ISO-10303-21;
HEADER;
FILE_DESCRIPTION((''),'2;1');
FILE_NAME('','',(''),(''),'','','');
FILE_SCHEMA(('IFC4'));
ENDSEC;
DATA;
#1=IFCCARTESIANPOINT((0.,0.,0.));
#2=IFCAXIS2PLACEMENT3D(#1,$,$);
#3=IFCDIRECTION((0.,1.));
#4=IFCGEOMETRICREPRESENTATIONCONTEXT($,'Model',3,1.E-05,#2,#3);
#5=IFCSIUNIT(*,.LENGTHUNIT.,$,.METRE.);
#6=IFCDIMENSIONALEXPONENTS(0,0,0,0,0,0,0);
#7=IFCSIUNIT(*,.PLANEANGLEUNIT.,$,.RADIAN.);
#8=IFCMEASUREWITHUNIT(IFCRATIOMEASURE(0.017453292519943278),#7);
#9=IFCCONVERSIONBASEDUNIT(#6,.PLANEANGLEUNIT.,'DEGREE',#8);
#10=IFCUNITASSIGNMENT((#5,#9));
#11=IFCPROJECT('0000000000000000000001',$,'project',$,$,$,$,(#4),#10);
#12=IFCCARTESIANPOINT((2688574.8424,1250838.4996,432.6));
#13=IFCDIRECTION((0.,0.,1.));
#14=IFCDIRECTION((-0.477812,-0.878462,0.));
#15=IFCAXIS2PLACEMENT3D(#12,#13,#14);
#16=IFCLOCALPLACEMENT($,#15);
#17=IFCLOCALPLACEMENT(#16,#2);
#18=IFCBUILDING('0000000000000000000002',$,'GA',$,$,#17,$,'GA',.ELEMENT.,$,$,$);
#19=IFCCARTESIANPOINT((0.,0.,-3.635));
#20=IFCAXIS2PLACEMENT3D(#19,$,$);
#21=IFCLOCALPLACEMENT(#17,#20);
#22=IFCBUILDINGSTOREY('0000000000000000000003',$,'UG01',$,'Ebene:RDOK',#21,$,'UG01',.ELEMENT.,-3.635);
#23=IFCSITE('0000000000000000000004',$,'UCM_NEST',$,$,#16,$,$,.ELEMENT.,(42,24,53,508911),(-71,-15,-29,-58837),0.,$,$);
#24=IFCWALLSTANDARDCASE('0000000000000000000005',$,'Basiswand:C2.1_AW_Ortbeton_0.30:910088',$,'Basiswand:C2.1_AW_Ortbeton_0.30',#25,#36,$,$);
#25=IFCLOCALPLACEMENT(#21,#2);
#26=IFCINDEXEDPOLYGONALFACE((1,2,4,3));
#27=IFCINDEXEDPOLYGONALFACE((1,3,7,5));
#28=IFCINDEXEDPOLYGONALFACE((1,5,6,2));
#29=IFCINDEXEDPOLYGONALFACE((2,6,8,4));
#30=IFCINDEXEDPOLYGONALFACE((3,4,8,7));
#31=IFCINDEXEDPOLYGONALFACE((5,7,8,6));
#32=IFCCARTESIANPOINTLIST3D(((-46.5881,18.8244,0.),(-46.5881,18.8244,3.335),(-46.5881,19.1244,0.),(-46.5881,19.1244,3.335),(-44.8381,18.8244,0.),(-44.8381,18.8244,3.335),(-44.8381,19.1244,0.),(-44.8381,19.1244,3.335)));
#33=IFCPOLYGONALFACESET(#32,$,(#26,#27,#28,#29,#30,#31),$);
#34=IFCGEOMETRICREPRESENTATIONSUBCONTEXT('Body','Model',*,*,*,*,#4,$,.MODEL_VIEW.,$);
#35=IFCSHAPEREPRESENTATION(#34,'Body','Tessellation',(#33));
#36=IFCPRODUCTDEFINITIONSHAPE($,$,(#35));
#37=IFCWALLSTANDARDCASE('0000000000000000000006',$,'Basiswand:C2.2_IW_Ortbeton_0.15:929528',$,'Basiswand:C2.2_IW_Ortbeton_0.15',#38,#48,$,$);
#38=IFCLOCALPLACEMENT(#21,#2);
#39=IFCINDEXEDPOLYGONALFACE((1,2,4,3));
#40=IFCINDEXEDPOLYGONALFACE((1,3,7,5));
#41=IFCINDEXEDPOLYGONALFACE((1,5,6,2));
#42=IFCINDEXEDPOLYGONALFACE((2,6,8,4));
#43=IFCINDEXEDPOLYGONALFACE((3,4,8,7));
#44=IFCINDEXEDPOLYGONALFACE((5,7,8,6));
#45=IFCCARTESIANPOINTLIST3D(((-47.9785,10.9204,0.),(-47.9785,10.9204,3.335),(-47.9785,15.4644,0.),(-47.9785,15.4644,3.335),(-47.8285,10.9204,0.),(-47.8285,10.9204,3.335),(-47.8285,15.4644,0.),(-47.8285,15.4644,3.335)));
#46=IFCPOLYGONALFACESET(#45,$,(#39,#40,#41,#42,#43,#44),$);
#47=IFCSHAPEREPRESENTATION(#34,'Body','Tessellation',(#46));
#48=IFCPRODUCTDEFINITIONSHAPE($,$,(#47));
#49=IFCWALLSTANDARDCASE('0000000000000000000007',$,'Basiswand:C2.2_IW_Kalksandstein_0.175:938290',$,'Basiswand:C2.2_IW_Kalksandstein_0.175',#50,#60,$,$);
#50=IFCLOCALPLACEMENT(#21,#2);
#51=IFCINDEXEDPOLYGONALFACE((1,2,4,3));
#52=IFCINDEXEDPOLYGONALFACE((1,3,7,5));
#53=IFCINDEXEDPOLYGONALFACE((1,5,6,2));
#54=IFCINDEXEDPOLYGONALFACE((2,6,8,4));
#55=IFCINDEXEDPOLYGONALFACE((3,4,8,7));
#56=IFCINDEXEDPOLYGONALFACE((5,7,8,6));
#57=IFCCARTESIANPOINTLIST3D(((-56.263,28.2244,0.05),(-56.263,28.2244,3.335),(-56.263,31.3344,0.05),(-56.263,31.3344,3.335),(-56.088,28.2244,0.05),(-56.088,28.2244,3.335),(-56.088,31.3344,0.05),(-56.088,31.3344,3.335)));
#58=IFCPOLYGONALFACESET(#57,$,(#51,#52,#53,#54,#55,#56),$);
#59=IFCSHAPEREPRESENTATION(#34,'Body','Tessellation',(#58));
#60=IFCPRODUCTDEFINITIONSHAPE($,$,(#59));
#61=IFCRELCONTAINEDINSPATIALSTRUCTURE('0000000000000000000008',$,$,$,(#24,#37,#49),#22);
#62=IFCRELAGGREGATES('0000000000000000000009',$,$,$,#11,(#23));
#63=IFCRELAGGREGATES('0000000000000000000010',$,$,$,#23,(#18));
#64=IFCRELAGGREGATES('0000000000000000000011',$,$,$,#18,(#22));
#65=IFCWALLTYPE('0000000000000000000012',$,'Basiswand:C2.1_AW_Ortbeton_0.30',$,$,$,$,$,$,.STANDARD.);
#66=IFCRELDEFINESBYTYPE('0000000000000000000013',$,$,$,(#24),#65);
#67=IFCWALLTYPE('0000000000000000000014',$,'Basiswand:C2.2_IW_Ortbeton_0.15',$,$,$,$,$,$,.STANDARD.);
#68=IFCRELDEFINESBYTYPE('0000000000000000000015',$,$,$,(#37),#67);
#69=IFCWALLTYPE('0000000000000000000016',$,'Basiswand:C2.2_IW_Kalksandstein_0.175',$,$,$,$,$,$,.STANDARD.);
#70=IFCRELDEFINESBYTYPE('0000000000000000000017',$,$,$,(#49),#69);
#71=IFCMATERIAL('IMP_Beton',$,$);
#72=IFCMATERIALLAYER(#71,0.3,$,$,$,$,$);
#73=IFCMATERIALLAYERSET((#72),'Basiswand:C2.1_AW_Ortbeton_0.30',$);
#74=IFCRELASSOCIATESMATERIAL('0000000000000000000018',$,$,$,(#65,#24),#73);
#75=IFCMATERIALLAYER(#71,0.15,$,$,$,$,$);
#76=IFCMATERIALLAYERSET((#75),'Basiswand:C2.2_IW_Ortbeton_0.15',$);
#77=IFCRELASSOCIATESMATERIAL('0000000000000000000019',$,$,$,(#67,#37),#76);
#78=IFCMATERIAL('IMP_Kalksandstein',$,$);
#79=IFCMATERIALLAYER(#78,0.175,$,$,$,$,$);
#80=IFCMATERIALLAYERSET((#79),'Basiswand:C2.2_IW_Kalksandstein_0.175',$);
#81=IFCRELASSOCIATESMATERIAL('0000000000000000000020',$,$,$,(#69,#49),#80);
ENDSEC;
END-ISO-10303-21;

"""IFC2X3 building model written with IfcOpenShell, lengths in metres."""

from ifc_helpers import new_model, entity, si_unit, converted_unit, direction, frame, frame_2d, origin, place, context, subcontext, project, spatial, polyline, rectangle, extrude, clip, bounded_halfspace, material, layer, layer_set, layer_usage, type_object, element, save


model = new_model("IFC2X3")

# Units and contexts
model_context = context("Model", 3, precision=1e-05, world=origin(), true_north=direction((0.0, 1.0)))
body_context = subcontext(model_context, "Body", "Model", "MODEL_VIEW")
ifc_project = project(units=[si_unit("LENGTHUNIT", "METRE"), converted_unit("PLANEANGLEUNIT", "DEGREE", entity("IfcRatioMeasure", 0.017453292519943278), si_unit("PLANEANGLEUNIT", "RADIAN"), dimensions=[0, 0, 0, 0, 0, 0, 0])], contexts=[model_context])

# Site, building, storey
site_placement = place(None, frame((2688574.8424, 1250838.4996, 432.6), z_axis=(0.0, 0.0, 1.0), x_axis=(-0.477812, -0.878462, 0.0)))
site = spatial("IfcSite", under=ifc_project, at=site_placement, Name="UCM_NEST", CompositionType="ELEMENT", RefLatitude=(42, 24, 53, 508911), RefLongitude=(-71, -15, -29, -58837), RefElevation=0.0)
building_placement = place(site_placement, origin())
building = spatial("IfcBuilding", under=site, at=building_placement, Name="GA", LongName="GA", CompositionType="ELEMENT")
storey_placement = place(building_placement, frame((0.0, 0.0, -3.635)))
storey = spatial("IfcBuildingStorey", under=building, at=storey_placement, Name="UG01", ObjectType="Ebene:RDOK", LongName="UG01", CompositionType="ELEMENT", Elevation=-3.635)

# Shared definitions
ifc_material_1 = material(Name="IMP_Beton")

# Walls
ifc_layer_1 = layer(ifc_material_1, 0.3)
ifc_layer_set_1 = layer_set([ifc_layer_1], Name="Basiswand:C2.1_AW_Ortbeton_0.30")
ifc_layer_usage_1 = layer_usage(ifc_layer_set_1, "AXIS2", "NEGATIVE", 0.15)
wall_type_1 = type_object("IfcWallType", Name="Basiswand:C2.1_AW_Ortbeton_0.30", PredefinedType="STANDARD", material=ifc_layer_set_1)
wall_1_placement = place(storey_placement, frame((-46.5881, 18.9744, 0.0)))
element("IfcWallStandardCase", 1, at=wall_1_placement, inside=storey, type_object=wall_type_1, material=ifc_layer_usage_1, Name="Basiswand:C2.1_AW_Ortbeton_0.30:910088", ObjectType="Basiswand:C2.1_AW_Ortbeton_0.30", context=body_context, shape_type="SweptSolid", body=[
    extrude(rectangle(XDim=1.75, YDim=0.3, at=frame_2d((0.875, 0.0), x_axis=(-1.0, 0.0))), origin(), (0.0, 0.0, 1.0), 3.335),
])
ifc_layer_2 = layer(ifc_material_1, 0.15)
ifc_layer_set_2 = layer_set([ifc_layer_2], Name="Basiswand:C2.2_IW_Ortbeton_0.15")
ifc_layer_usage_2 = layer_usage(ifc_layer_set_2, "AXIS2", "NEGATIVE", 0.075)
wall_type_2 = type_object("IfcWallType", Name="Basiswand:C2.2_IW_Ortbeton_0.15", PredefinedType="STANDARD", material=ifc_layer_set_2)
wall_2_placement = place(storey_placement, frame((-47.9035, 15.4644, 0.0), z_axis=(0.0, 0.0, 1.0), x_axis=(0.0, -1.0, 0.0)))
element("IfcWallStandardCase", 2, at=wall_2_placement, inside=storey, type_object=wall_type_2, material=ifc_layer_usage_2, Name="Basiswand:C2.2_IW_Ortbeton_0.15:929528", ObjectType="Basiswand:C2.2_IW_Ortbeton_0.15", context=body_context, shape_type="SweptSolid", body=[
    extrude(rectangle(XDim=4.544, YDim=0.15, at=frame_2d((2.272, 0.0), x_axis=(-1.0, 0.0))), origin(), (0.0, 0.0, 1.0), 3.335),
])
ifc_material_2 = material(Name="IMP_Kalksandstein")
ifc_layer_3 = layer(ifc_material_2, 0.175)
ifc_layer_set_3 = layer_set([ifc_layer_3], Name="Basiswand:C2.2_IW_Kalksandstein_0.175")
ifc_layer_usage_3 = layer_usage(ifc_layer_set_3, "AXIS2", "NEGATIVE", 0.0875)
wall_type_3 = type_object("IfcWallType", Name="Basiswand:C2.2_IW_Kalksandstein_0.175", PredefinedType="STANDARD", material=ifc_layer_set_3)
wall_3_placement = place(storey_placement, frame((-56.1755, 28.2244, 0.05), z_axis=(0.0, 0.0, 1.0), x_axis=(0.0, 1.0, 0.0)))
element("IfcWallStandardCase", 3, at=wall_3_placement, inside=storey, type_object=wall_type_3, material=ifc_layer_usage_3, Name="Basiswand:C2.2_IW_Kalksandstein_0.175:938290", ObjectType="Basiswand:C2.2_IW_Kalksandstein_0.175", context=body_context, shape_type="Clipping", body=[
    clip(extrude(rectangle(XDim=3.11, YDim=0.175, at=frame_2d((1.555, 0.0), x_axis=(-1.0, 0.0))), origin(), (0.0, 0.0, 1.0), 3.285), bounded_halfspace(frame((3.11, -0.0875, 0.0)), True, frame((3.11, -0.0875, 0.0)), polyline([(0.0, 0.0), (0.0, 0.175), (-3.11, 0.175), (-3.11, 0.0), (0.0, 0.0)]))),
])

save(model, "model.ifc")
